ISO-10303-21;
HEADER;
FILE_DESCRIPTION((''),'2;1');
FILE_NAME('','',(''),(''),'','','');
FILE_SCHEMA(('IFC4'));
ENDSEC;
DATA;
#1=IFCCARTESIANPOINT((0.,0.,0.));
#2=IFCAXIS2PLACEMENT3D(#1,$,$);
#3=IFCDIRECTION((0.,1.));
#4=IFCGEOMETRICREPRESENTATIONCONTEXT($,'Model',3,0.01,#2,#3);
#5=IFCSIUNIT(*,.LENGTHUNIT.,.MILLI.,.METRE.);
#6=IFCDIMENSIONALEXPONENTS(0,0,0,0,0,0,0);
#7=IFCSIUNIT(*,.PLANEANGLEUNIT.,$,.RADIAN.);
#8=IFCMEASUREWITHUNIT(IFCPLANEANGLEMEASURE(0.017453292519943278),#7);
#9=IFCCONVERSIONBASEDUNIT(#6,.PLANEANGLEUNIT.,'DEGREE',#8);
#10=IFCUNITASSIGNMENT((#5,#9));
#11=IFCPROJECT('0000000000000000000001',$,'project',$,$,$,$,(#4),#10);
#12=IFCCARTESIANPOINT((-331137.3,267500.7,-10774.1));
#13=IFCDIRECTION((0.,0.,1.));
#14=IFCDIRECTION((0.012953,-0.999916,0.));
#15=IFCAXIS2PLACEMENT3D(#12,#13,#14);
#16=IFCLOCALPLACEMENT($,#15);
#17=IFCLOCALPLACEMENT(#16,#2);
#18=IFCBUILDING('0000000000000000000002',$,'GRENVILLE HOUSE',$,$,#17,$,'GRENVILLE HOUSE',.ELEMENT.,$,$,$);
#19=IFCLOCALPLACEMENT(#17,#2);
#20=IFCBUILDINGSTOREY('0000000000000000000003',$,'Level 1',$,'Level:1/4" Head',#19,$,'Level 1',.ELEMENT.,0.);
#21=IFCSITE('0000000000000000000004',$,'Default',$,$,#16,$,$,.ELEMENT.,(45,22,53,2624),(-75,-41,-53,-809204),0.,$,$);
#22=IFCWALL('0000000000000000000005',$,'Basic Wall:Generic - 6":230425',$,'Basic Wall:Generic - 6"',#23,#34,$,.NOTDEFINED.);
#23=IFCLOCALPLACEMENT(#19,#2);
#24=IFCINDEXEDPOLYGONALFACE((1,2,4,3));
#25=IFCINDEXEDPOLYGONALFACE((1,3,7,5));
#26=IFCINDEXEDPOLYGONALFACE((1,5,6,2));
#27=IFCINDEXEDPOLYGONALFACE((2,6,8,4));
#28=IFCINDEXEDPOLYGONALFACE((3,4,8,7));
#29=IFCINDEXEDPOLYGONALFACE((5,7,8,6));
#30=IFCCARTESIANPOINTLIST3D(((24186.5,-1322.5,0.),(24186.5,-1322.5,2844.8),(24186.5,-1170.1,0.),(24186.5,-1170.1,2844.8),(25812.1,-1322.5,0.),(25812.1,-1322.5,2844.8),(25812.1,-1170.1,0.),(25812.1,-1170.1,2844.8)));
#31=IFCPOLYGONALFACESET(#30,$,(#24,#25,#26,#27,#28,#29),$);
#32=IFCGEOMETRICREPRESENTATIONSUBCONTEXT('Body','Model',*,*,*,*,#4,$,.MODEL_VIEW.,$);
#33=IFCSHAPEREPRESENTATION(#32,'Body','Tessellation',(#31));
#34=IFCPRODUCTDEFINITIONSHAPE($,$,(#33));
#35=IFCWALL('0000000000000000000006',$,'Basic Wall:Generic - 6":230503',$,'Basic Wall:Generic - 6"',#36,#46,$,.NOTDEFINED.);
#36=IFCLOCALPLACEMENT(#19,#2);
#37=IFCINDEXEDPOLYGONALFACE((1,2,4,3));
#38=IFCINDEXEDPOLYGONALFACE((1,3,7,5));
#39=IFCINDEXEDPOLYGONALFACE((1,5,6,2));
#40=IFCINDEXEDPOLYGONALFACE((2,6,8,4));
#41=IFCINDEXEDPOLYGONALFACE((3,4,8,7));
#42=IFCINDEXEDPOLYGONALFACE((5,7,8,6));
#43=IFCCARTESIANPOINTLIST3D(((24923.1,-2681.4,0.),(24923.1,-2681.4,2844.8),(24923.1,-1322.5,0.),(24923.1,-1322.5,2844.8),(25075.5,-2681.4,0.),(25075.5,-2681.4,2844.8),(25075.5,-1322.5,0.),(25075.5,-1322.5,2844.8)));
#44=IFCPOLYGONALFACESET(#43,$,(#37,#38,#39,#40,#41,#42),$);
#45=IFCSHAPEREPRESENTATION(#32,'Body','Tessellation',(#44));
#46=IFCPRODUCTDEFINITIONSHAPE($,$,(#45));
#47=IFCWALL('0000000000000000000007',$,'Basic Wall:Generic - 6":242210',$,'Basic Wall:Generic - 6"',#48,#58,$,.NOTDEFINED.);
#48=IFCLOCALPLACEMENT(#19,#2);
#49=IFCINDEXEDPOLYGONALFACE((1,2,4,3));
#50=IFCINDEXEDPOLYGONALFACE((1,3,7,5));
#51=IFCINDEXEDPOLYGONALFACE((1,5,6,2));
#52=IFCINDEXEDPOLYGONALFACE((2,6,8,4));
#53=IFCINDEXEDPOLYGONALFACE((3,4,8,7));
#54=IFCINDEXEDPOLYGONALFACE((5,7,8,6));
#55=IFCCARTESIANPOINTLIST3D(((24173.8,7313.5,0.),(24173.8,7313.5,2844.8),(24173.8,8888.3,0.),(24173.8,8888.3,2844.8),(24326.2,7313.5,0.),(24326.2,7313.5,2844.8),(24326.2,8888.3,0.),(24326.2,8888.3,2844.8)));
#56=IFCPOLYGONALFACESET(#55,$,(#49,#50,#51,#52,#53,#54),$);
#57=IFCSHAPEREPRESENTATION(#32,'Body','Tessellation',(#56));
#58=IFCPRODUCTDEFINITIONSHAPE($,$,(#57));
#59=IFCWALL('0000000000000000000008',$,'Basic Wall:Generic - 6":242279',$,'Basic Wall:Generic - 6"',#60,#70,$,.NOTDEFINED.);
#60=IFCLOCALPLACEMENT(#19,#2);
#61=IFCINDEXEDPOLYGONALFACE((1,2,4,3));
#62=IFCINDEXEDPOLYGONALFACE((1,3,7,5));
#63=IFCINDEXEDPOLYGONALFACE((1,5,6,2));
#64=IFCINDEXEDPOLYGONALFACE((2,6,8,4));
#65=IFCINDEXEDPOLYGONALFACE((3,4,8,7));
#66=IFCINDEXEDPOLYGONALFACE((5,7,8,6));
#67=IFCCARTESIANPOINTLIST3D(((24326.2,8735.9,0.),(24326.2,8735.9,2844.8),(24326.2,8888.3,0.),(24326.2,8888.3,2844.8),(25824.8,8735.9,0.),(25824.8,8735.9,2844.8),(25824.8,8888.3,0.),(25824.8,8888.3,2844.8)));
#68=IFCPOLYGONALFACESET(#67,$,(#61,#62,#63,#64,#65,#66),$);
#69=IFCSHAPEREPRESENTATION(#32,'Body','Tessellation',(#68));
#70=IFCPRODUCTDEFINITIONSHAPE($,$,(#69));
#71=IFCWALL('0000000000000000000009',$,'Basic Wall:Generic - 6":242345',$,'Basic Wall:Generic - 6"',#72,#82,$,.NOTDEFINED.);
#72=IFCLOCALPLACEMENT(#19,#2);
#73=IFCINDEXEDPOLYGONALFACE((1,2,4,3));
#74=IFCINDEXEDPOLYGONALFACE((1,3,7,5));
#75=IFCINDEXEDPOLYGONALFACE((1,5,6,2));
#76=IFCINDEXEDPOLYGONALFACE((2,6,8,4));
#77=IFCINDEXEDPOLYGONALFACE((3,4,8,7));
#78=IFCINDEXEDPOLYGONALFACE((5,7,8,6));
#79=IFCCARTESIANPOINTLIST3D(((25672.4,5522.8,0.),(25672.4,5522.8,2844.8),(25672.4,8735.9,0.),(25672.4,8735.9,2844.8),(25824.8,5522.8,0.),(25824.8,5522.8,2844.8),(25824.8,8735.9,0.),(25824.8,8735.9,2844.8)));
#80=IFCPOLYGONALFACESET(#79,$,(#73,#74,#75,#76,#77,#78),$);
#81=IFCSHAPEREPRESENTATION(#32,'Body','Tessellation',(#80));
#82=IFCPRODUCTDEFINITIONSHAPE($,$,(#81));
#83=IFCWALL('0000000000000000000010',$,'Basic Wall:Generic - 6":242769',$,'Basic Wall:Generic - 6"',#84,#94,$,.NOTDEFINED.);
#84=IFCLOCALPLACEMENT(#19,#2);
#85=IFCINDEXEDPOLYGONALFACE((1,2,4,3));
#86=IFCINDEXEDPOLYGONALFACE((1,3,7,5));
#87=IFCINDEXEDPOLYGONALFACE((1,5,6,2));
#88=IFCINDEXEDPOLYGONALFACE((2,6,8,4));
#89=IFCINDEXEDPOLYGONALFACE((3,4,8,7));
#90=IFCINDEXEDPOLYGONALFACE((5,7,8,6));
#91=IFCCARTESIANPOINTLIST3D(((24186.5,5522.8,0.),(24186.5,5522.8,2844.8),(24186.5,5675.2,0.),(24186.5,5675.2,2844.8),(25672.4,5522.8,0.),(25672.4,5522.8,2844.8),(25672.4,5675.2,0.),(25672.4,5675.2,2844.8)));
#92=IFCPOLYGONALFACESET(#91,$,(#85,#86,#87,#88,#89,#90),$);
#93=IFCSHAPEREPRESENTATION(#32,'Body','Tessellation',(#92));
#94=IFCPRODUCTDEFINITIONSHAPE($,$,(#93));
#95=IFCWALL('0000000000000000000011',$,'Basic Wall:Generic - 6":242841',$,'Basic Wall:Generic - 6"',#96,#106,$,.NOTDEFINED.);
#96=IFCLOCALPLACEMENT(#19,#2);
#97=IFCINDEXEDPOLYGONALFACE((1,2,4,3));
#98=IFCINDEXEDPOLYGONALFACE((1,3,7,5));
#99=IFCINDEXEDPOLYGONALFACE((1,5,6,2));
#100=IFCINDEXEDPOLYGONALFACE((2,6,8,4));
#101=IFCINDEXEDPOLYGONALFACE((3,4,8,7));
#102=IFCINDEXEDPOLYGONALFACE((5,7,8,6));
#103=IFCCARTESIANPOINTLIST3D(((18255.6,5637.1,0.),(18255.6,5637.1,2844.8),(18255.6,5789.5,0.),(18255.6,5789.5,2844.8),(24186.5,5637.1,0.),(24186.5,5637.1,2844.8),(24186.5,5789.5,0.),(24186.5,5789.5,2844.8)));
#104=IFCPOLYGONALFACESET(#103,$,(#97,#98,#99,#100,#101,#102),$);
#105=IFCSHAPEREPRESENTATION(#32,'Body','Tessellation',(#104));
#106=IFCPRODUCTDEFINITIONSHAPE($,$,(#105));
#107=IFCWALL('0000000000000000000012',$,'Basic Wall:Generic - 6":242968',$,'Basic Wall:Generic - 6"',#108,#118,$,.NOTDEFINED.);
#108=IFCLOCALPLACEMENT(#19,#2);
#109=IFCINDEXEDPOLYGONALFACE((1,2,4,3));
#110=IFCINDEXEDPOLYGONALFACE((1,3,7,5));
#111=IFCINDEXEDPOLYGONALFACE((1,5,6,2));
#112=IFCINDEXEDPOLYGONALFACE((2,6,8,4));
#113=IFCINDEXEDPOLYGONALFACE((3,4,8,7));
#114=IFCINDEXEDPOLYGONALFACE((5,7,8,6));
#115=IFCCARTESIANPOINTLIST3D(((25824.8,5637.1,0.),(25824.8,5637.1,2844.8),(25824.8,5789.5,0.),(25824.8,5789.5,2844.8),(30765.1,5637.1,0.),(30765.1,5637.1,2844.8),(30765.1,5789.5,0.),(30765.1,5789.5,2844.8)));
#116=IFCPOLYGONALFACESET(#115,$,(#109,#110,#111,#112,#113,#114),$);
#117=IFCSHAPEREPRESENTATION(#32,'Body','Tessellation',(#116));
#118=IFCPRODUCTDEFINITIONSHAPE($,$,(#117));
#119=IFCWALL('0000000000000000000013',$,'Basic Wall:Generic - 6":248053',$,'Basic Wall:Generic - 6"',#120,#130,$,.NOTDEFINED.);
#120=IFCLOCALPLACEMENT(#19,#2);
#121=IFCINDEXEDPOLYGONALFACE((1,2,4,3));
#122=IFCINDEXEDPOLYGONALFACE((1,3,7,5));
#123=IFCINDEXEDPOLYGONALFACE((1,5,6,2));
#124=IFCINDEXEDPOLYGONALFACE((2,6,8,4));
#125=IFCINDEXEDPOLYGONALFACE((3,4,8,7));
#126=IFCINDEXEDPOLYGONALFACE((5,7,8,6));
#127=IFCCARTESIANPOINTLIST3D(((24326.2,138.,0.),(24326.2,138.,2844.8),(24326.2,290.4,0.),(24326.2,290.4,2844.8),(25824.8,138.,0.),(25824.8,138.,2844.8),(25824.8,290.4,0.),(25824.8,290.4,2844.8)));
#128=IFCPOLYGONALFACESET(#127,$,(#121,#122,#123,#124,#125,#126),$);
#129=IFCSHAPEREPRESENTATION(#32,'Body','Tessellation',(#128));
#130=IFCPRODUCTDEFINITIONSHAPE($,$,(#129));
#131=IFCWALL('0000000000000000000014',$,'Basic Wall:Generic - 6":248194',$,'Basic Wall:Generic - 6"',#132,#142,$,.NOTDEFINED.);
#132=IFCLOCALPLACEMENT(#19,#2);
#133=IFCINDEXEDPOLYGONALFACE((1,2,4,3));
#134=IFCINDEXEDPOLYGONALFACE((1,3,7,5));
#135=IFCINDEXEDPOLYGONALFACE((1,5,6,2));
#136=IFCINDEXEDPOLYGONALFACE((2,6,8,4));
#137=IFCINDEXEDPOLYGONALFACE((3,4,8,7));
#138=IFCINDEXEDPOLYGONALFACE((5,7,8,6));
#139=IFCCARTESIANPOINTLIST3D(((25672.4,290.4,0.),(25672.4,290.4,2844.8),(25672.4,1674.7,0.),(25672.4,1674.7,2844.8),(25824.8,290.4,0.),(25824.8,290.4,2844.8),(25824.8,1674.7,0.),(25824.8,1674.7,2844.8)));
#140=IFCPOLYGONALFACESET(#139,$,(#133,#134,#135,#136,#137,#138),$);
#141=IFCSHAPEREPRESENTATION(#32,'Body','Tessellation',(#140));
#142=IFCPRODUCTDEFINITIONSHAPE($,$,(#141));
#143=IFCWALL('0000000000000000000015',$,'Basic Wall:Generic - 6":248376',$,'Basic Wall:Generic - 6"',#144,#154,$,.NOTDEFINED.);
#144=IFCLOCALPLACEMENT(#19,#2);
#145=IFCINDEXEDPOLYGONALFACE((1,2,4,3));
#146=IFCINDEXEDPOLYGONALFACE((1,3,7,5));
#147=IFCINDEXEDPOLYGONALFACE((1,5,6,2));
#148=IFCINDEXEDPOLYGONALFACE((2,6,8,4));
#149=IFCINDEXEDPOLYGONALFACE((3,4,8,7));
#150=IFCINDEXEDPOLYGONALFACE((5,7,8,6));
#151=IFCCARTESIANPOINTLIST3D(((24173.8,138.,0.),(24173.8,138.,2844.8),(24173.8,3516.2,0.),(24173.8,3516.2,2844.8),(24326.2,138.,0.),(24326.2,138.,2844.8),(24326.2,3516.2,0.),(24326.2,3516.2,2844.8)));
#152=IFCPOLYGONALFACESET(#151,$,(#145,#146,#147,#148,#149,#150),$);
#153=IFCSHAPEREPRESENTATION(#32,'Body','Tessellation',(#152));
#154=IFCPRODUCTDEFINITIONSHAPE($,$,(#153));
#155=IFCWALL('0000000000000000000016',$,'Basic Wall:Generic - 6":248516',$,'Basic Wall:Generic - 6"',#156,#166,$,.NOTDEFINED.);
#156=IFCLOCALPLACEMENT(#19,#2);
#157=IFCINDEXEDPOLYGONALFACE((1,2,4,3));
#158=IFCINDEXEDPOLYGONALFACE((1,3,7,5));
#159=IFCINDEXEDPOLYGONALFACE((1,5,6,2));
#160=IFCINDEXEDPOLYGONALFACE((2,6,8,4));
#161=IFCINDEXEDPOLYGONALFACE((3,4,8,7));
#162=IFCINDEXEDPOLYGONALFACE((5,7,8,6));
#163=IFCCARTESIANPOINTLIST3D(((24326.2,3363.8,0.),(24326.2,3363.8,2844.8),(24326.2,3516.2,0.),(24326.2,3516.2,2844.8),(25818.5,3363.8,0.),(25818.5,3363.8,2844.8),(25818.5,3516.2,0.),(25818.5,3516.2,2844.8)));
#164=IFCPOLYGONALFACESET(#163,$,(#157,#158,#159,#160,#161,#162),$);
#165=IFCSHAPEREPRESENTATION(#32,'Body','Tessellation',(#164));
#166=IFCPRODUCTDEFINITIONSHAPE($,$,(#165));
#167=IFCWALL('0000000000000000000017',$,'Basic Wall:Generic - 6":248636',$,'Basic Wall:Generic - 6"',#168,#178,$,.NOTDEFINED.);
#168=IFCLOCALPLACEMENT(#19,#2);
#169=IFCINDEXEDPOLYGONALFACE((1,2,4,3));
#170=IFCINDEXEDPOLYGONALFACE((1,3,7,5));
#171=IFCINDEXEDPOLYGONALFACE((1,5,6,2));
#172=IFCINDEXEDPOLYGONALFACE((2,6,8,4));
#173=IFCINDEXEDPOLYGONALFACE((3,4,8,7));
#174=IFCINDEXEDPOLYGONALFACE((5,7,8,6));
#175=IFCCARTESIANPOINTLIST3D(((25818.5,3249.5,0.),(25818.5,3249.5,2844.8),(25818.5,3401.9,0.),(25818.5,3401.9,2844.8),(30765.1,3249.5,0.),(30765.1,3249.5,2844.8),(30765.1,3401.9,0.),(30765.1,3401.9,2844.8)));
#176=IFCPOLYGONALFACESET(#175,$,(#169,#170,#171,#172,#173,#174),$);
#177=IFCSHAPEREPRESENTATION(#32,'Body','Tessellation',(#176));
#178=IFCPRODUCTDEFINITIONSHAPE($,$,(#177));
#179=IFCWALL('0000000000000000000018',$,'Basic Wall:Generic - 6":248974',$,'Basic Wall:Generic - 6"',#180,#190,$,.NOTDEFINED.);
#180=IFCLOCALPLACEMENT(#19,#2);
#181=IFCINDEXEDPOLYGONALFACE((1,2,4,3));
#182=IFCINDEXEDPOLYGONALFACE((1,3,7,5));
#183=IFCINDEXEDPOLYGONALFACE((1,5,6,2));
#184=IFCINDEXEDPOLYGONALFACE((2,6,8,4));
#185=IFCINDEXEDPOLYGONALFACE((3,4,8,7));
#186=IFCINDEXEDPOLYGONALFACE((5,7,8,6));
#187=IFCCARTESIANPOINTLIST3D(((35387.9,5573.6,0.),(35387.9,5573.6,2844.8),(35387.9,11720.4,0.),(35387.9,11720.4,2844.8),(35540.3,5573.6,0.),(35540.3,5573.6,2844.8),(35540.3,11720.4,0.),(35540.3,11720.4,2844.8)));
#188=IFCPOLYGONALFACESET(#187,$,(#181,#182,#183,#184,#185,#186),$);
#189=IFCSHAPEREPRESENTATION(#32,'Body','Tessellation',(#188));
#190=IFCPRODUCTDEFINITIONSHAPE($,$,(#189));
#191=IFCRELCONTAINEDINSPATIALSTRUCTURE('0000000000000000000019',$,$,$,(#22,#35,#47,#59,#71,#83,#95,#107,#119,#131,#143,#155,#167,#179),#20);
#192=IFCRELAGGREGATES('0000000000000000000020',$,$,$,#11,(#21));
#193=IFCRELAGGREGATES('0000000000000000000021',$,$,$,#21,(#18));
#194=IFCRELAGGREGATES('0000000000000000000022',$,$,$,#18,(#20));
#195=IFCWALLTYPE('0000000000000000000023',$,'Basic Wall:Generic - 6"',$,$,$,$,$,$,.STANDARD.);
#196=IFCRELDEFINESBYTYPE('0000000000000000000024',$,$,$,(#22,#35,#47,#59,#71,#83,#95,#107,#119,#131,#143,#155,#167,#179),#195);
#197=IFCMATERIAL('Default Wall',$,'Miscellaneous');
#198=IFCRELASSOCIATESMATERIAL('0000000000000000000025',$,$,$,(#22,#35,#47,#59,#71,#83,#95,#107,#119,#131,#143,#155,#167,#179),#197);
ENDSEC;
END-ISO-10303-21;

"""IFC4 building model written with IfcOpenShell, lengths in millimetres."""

from ifc_helpers import new_model, entity, si_unit, converted_unit, direction, frame, origin, place, context, subcontext, project, spatial, indexed_curve, outline, extrude, material, type_object, element, save


model = new_model("IFC4")

# Units and contexts
model_context = context("Model", 3, precision=0.01, world=origin(), true_north=direction((0.0, 1.0)))
body_context = subcontext(model_context, "Body", "Model", "MODEL_VIEW")
ifc_project = project(units=[si_unit("LENGTHUNIT", "METRE", prefix="MILLI"), converted_unit("PLANEANGLEUNIT", "DEGREE", entity("IfcPlaneAngleMeasure", 0.017453292519943278), si_unit("PLANEANGLEUNIT", "RADIAN"), dimensions=[0, 0, 0, 0, 0, 0, 0])], contexts=[model_context])

# Site, building, storey
site_placement = place(None, frame((-331137.3, 267500.7, -10774.1), z_axis=(0.0, 0.0, 1.0), x_axis=(0.012953, -0.999916, 0.0)))
site = spatial("IfcSite", under=ifc_project, at=site_placement, Name="Default", CompositionType="ELEMENT", RefLatitude=(45, 22, 53, 2624), RefLongitude=(-75, -41, -53, -809204), RefElevation=0.0)
building_placement = place(site_placement, origin())
building = spatial("IfcBuilding", under=site, at=building_placement, Name="GRENVILLE HOUSE", LongName="GRENVILLE HOUSE", CompositionType="ELEMENT")
storey_placement = place(building_placement, origin())
storey = spatial("IfcBuildingStorey", under=building, at=storey_placement, Name="Level 1", ObjectType="Level:1/4\" Head", LongName="Level 1", CompositionType="ELEMENT", Elevation=0.0)

# Walls
ifc_material = material(Name="Default Wall", Category="Miscellaneous")
wall_type_1 = type_object("IfcWallType", Name="Basic Wall:Generic - 6\"", PredefinedType="STANDARD")
wall_1_placement = place(storey_placement, frame((24186.5, -1246.3, 0.0)))
element("IfcWall", 1, at=wall_1_placement, inside=storey, type_object=wall_type_1, material=ifc_material, Name="Basic Wall:Generic - 6\":230425", ObjectType="Basic Wall:Generic - 6\"", PredefinedType="NOTDEFINED", context=body_context, shape_type="SweptSolid", body=[
    extrude(outline(indexed_curve([(1625.6, 76.2), (0.0, 76.2), (0.0, -76.2), (1625.6, -76.2), (1625.6, 76.2)], self_intersect=False)), origin(), (0.0, 0.0, 1.0), 2844.8),
])
wall_2_placement = place(storey_placement, frame((24999.3, -1322.5, 0.0), z_axis=(0.0, 0.0, 1.0), x_axis=(0.0, -1.0, 0.0)))
element("IfcWall", 2, at=wall_2_placement, inside=storey, type_object=wall_type_1, material=ifc_material, Name="Basic Wall:Generic - 6\":230503", ObjectType="Basic Wall:Generic - 6\"", PredefinedType="NOTDEFINED", context=body_context, shape_type="SweptSolid", body=[
    extrude(outline(indexed_curve([(1358.9, 76.2), (0.0, 76.2), (0.0, -76.2), (1358.9, -76.2), (1358.9, 76.2)], self_intersect=False)), origin(), (0.0, 0.0, 1.0), 2844.8),
])
wall_3_placement = place(storey_placement, frame((24250.0, 7313.5, 0.0), z_axis=(0.0, 0.0, 1.0), x_axis=(0.0, 1.0, 0.0)))
element("IfcWall", 3, at=wall_3_placement, inside=storey, type_object=wall_type_1, material=ifc_material, Name="Basic Wall:Generic - 6\":242210", ObjectType="Basic Wall:Generic - 6\"", PredefinedType="NOTDEFINED", context=body_context, shape_type="SweptSolid", body=[
    extrude(outline(indexed_curve([(1574.8, 76.2), (0.0, 76.2), (0.0, -76.2), (1574.8, -76.2), (1574.8, 76.2)], self_intersect=False)), origin(), (0.0, 0.0, 1.0), 2844.8),
])
wall_4_placement = place(storey_placement, frame((24326.2, 8812.1, 0.0)))
element("IfcWall", 4, at=wall_4_placement, inside=storey, type_object=wall_type_1, material=ifc_material, Name="Basic Wall:Generic - 6\":242279", ObjectType="Basic Wall:Generic - 6\"", PredefinedType="NOTDEFINED", context=body_context, shape_type="SweptSolid", body=[
    extrude(outline(indexed_curve([(1498.6, 76.2), (0.0, 76.2), (0.0, -76.2), (1498.6, -76.2), (1498.6, 76.2)], self_intersect=False)), origin(), (0.0, 0.0, 1.0), 2844.8),
])
wall_5_placement = place(storey_placement, frame((25748.6, 8735.9, 0.0), z_axis=(0.0, 0.0, 1.0), x_axis=(0.0, -1.0, 0.0)))
element("IfcWall", 5, at=wall_5_placement, inside=storey, type_object=wall_type_1, material=ifc_material, Name="Basic Wall:Generic - 6\":242345", ObjectType="Basic Wall:Generic - 6\"", PredefinedType="NOTDEFINED", context=body_context, shape_type="SweptSolid", body=[
    extrude(outline(indexed_curve([(3213.1, 76.2), (0.0, 76.2), (0.0, -76.2), (3213.1, -76.2), (3213.1, 76.2)], self_intersect=False)), origin(), (0.0, 0.0, 1.0), 2844.8),
])
wall_6_placement = place(storey_placement, frame((25672.4, 5599.0, 0.0), z_axis=(0.0, 0.0, 1.0), x_axis=(-1.0, 0.0, 0.0)))
element("IfcWall", 6, at=wall_6_placement, inside=storey, type_object=wall_type_1, material=ifc_material, Name="Basic Wall:Generic - 6\":242769", ObjectType="Basic Wall:Generic - 6\"", PredefinedType="NOTDEFINED", context=body_context, shape_type="SweptSolid", body=[
    extrude(outline(indexed_curve([(1485.9, 76.2), (0.0, 76.2), (0.0, -76.2), (1485.9, -76.2), (1485.9, 76.2)], self_intersect=False)), origin(), (0.0, 0.0, 1.0), 2844.8),
])
wall_7_placement = place(storey_placement, frame((24186.5, 5713.3, 0.0), z_axis=(0.0, 0.0, 1.0), x_axis=(-1.0, 0.0, 0.0)))
element("IfcWall", 7, at=wall_7_placement, inside=storey, type_object=wall_type_1, material=ifc_material, Name="Basic Wall:Generic - 6\":242841", ObjectType="Basic Wall:Generic - 6\"", PredefinedType="NOTDEFINED", context=body_context, shape_type="SweptSolid", body=[
    extrude(outline(indexed_curve([(5930.9, 76.2), (0.0, 76.2), (0.0, -76.2), (5930.9, -76.2), (5930.9, 76.2)], self_intersect=False)), origin(), (0.0, 0.0, 1.0), 2844.8),
])
wall_8_placement = place(storey_placement, frame((30765.1, 5713.3, 0.0), z_axis=(0.0, 0.0, 1.0), x_axis=(-1.0, 0.0, 0.0)))
element("IfcWall", 8, at=wall_8_placement, inside=storey, type_object=wall_type_1, material=ifc_material, Name="Basic Wall:Generic - 6\":242968", ObjectType="Basic Wall:Generic - 6\"", PredefinedType="NOTDEFINED", context=body_context, shape_type="SweptSolid", body=[
    extrude(outline(indexed_curve([(4940.3, 76.2), (0.0, 76.2), (0.0, -76.2), (4940.3, -76.2), (4940.3, 76.2)], self_intersect=False)), origin(), (0.0, 0.0, 1.0), 2844.8),
])
wall_9_placement = place(storey_placement, frame((25824.8, 214.2, 0.0), z_axis=(0.0, 0.0, 1.0), x_axis=(-1.0, 0.0, 0.0)))
element("IfcWall", 9, at=wall_9_placement, inside=storey, type_object=wall_type_1, material=ifc_material, Name="Basic Wall:Generic - 6\":248053", ObjectType="Basic Wall:Generic - 6\"", PredefinedType="NOTDEFINED", context=body_context, shape_type="SweptSolid", body=[
    extrude(outline(indexed_curve([(1498.6, 76.2), (0.0, 76.2), (0.0, -76.2), (1498.6, -76.2), (1498.6, 76.2)], self_intersect=False)), origin(), (0.0, 0.0, 1.0), 2844.8),
])
wall_10_placement = place(storey_placement, frame((25748.6, 1674.7, 0.0), z_axis=(0.0, 0.0, 1.0), x_axis=(0.0, -1.0, 0.0)))
element("IfcWall", 10, at=wall_10_placement, inside=storey, type_object=wall_type_1, material=ifc_material, Name="Basic Wall:Generic - 6\":248194", ObjectType="Basic Wall:Generic - 6\"", PredefinedType="NOTDEFINED", context=body_context, shape_type="SweptSolid", body=[
    extrude(outline(indexed_curve([(1384.3, 76.2), (0.0, 76.2), (0.0, -76.2), (1384.3, -76.2), (1384.3, 76.2)], self_intersect=False)), origin(), (0.0, 0.0, 1.0), 2844.8),
])
wall_11_placement = place(storey_placement, frame((24250.0, 138.0, 0.0), z_axis=(0.0, 0.0, 1.0), x_axis=(0.0, 1.0, 0.0)))
element("IfcWall", 11, at=wall_11_placement, inside=storey, type_object=wall_type_1, material=ifc_material, Name="Basic Wall:Generic - 6\":248376", ObjectType="Basic Wall:Generic - 6\"", PredefinedType="NOTDEFINED", context=body_context, shape_type="SweptSolid", body=[
    extrude(outline(indexed_curve([(3378.2, 76.2), (0.0, 76.2), (0.0, -76.2), (3378.2, -76.2), (3378.2, 76.2)], self_intersect=False)), origin(), (0.0, 0.0, 1.0), 2844.8),
])
wall_12_placement = place(storey_placement, frame((25818.5, 3440.0, 0.0), z_axis=(0.0, 0.0, 1.0), x_axis=(-1.0, 0.0, 0.0)))
element("IfcWall", 12, at=wall_12_placement, inside=storey, type_object=wall_type_1, material=ifc_material, Name="Basic Wall:Generic - 6\":248516", ObjectType="Basic Wall:Generic - 6\"", PredefinedType="NOTDEFINED", context=body_context, shape_type="SweptSolid", body=[
    extrude(outline(indexed_curve([(1492.3, 76.2), (0.0, 76.2), (0.0, -76.2), (1492.3, -76.2), (1492.3, 76.2)], self_intersect=False)), origin(), (0.0, 0.0, 1.0), 2844.8),
])
wall_13_placement = place(storey_placement, frame((25818.5, 3325.7, 0.0)))
element("IfcWall", 13, at=wall_13_placement, inside=storey, type_object=wall_type_1, material=ifc_material, Name="Basic Wall:Generic - 6\":248636", ObjectType="Basic Wall:Generic - 6\"", PredefinedType="NOTDEFINED", context=body_context, shape_type="SweptSolid", body=[
    extrude(outline(indexed_curve([(4946.6, 76.2), (0.0, 76.2), (0.0, -76.2), (4946.6, -76.2), (4946.6, 76.2)], self_intersect=False)), origin(), (0.0, 0.0, 1.0), 2844.8),
])
wall_14_placement = place(storey_placement, frame((35464.1, 11720.4, 0.0), z_axis=(0.0, 0.0, 1.0), x_axis=(0.0, -1.0, 0.0)))
element("IfcWall", 14, at=wall_14_placement, inside=storey, type_object=wall_type_1, material=ifc_material, Name="Basic Wall:Generic - 6\":248974", ObjectType="Basic Wall:Generic - 6\"", PredefinedType="NOTDEFINED", context=body_context, shape_type="SweptSolid", body=[
    extrude(outline(indexed_curve([(6146.8, 76.2), (0.0, 76.2), (0.0, -76.2), (6146.8, -76.2), (6146.8, 76.2)], self_intersect=False)), origin(), (0.0, 0.0, 1.0), 2844.8),
])

save(model, "model.ifc")
